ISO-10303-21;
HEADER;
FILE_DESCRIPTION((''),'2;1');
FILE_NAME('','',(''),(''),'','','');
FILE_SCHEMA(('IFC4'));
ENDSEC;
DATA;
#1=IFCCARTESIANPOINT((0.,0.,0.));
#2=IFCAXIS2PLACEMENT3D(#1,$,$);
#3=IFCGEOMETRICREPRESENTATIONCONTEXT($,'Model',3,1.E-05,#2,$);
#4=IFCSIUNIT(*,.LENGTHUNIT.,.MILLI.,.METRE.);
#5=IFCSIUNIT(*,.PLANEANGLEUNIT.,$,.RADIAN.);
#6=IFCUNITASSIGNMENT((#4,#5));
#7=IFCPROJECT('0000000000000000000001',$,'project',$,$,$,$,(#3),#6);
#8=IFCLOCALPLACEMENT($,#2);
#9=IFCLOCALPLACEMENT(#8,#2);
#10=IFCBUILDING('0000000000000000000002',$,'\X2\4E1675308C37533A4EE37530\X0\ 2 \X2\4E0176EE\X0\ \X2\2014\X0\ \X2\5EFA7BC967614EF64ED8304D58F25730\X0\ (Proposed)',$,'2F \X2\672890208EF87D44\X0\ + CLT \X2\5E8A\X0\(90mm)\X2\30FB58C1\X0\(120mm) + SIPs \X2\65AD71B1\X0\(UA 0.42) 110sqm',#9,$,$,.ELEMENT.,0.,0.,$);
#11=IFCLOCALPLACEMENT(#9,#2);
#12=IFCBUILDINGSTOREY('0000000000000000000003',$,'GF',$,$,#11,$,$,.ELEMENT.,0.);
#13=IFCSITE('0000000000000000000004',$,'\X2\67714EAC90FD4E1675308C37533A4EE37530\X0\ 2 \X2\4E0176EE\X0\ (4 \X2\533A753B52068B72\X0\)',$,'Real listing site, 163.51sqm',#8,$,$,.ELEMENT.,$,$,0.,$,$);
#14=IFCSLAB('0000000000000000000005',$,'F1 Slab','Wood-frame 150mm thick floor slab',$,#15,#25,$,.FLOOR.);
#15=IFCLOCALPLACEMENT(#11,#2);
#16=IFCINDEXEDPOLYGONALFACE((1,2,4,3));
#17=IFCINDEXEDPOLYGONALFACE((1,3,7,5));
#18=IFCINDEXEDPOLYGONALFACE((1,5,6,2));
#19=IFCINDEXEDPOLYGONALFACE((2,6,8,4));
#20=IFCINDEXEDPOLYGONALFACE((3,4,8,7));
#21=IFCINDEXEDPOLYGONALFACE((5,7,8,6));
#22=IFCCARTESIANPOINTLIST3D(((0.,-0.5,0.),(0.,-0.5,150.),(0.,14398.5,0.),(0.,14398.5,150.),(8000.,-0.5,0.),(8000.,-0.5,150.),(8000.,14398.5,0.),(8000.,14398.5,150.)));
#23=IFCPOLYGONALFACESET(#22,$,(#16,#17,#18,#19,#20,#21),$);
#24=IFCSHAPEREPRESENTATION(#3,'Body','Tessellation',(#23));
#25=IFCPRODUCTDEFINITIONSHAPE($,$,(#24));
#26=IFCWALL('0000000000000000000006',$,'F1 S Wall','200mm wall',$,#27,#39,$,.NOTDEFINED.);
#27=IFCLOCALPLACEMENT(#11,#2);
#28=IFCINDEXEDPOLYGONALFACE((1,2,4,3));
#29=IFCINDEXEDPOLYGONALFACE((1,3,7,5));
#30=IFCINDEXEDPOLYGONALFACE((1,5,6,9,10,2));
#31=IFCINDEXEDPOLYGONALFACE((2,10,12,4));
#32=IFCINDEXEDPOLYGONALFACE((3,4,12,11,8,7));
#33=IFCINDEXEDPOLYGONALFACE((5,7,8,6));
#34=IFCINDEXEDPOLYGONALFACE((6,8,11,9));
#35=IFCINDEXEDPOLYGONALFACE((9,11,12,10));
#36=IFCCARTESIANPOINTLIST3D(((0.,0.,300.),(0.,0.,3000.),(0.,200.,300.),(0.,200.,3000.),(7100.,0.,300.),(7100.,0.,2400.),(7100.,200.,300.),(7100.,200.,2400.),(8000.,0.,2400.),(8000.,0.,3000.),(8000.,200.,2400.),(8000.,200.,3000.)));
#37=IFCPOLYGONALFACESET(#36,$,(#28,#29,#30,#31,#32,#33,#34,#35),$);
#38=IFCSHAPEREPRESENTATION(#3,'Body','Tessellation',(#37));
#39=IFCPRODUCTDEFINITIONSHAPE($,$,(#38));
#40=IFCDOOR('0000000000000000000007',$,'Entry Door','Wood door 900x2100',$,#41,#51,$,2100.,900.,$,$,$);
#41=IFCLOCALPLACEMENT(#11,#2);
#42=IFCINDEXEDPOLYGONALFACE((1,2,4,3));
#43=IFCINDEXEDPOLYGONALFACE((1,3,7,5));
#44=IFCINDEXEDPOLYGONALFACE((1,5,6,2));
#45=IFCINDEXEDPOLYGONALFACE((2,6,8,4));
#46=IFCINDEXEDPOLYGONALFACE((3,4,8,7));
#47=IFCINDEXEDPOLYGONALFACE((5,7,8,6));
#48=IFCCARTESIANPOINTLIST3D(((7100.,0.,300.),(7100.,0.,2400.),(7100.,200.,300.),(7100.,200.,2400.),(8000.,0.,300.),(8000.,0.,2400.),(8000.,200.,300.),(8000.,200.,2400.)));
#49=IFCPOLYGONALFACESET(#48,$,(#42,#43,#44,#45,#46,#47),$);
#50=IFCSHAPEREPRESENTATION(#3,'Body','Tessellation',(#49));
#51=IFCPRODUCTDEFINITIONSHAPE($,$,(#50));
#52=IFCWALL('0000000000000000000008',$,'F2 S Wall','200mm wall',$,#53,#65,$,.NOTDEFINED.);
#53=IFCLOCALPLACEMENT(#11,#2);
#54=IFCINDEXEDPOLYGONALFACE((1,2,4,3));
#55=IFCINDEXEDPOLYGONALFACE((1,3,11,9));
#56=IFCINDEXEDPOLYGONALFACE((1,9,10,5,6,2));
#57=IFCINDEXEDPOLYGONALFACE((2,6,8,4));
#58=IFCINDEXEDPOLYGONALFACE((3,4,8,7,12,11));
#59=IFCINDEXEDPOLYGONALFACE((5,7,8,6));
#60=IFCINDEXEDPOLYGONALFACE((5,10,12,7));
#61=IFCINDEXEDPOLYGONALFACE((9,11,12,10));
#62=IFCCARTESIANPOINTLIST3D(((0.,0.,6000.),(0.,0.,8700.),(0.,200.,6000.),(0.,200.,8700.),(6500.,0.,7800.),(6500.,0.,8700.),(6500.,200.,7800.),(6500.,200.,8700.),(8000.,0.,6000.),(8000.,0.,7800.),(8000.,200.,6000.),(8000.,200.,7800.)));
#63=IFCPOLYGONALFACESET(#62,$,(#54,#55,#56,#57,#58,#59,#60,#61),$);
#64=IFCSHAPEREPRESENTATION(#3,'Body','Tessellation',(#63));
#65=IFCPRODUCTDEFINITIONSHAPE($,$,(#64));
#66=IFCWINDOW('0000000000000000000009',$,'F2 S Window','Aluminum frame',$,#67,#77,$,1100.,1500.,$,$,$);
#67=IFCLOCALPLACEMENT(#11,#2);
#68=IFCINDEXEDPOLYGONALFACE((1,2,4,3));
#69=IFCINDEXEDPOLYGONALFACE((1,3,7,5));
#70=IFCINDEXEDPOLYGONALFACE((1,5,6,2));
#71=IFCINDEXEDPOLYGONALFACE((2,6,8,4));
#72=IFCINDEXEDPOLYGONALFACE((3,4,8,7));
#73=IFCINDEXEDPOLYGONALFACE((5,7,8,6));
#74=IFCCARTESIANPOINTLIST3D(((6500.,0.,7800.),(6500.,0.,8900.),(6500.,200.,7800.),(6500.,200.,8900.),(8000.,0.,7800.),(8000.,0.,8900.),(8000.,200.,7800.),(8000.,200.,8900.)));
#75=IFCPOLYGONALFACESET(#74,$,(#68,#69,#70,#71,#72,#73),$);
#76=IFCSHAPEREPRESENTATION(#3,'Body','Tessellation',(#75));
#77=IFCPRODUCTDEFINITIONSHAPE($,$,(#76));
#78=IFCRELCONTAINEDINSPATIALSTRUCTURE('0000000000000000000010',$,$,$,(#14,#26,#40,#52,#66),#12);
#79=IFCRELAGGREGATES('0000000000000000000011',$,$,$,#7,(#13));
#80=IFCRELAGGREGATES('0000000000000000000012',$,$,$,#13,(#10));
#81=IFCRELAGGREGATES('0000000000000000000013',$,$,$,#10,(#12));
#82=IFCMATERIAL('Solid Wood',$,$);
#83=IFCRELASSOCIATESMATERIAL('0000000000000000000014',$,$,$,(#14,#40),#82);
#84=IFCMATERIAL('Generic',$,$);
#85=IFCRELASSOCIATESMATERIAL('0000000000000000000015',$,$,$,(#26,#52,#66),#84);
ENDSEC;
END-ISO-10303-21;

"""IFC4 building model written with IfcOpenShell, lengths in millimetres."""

from ifc_helpers import new_model, si_unit, frame, frame_2d, origin, place, context, project, spatial, rectangle, extrude, material, element, fill, save


model = new_model("IFC4")

# Units and contexts
model_context = context("Model", 3, precision=1e-05, world=origin())
ifc_project = project(units=[si_unit("LENGTHUNIT", "METRE", prefix="MILLI"), si_unit("PLANEANGLEUNIT", "RADIAN")], contexts=[model_context])

# Site, building, storey
site_placement = place(None, origin())
site = spatial("IfcSite", under=ifc_project, at=site_placement, Name="東京都世田谷区代田 2 丁目 (4 区画分譲)", ObjectType="Real listing site, 163.51sqm", CompositionType="ELEMENT", RefElevation=0.0)
building_placement = place(site_placement, origin())
building = spatial("IfcBuilding", under=site, at=building_placement, Name="世田谷区代田 2 丁目 — 建築条件付き売地 (Proposed)", ObjectType="2F 木造軸組 + CLT 床(90mm)・壁(120mm) + SIPs 断熱(UA 0.42) 110sqm", CompositionType="ELEMENT", ElevationOfRefHeight=0.0, ElevationOfTerrain=0.0)
storey_placement = place(building_placement, origin())
storey = spatial("IfcBuildingStorey", under=building, at=storey_placement, Name="GF", CompositionType="ELEMENT", Elevation=0.0)

# Slab
ifc_material_1 = material(Name="Solid Wood")
slab_1_placement = place(storey_placement, origin())
element("IfcSlab", 1, at=slab_1_placement, inside=storey, material=ifc_material_1, Name="F1 Slab", Description="Wood-frame 150mm thick floor slab", PredefinedType="FLOOR", context=model_context, shape_type="SweptSolid", body=[
    extrude(rectangle(XDim=8000.0, YDim=14399.0, at=frame_2d((4000.0, 7199.0))), origin(), (0.0, 0.0, 1.0), 150.0),
])

# Shared definitions
ifc_material_2 = material(Name="Generic")

# Wall, opening, door
wall_1_placement = place(storey_placement, frame((0.0, 0.0, 150.0)))
wall_1 = element("IfcWall", 2, at=wall_1_placement, inside=storey, material=ifc_material_2, Name="F1 S Wall", Description="200mm wall", PredefinedType="NOTDEFINED", context=model_context, shape_type="SweptSolid", body=[
    extrude(rectangle(XDim=8000.0, YDim=200.0, at=frame_2d((4000.0, 100.0))), frame((0.0, 0.0, 150.0)), (0.0, 0.0, 1.0), 2700.0),
])
opening_1_placement = place(storey_placement, frame((3550.0, 0.0, 150.0)))
opening_1 = element("IfcOpeningElement", 3, at=opening_1_placement, cuts=wall_1, PredefinedType="NOTDEFINED", context=model_context, shape_type="SweptSolid", body=[
    extrude(rectangle(XDim=900.0, YDim=200.0, at=frame_2d((450.0, 100.0))), frame((3550.0, 0.0, 150.0)), (0.0, 0.0, 1.0), 2100.0),
])
door_placement = place(storey_placement, frame((3550.0, 0.0, 150.0)))
door = element("IfcDoor", 4, at=door_placement, inside=storey, material=ifc_material_1, Name="Entry Door", Description="Wood door 900x2100", OverallHeight=2100.0, OverallWidth=900.0, context=model_context, shape_type="SweptSolid", body=[
    extrude(rectangle(XDim=900.0, YDim=200.0, at=frame_2d((450.0, 100.0))), frame((3550.0, 0.0, 150.0)), (0.0, 0.0, 1.0), 2100.0),
])
fill(opening_1, door)

# Wall, opening, window
wall_2_placement = place(storey_placement, frame((0.0, 0.0, 3000.0)))
wall_2 = element("IfcWall", 5, at=wall_2_placement, inside=storey, material=ifc_material_2, Name="F2 S Wall", Description="200mm wall", PredefinedType="NOTDEFINED", context=model_context, shape_type="SweptSolid", body=[
    extrude(rectangle(XDim=8000.0, YDim=200.0, at=frame_2d((4000.0, 100.0))), frame((0.0, 0.0, 3000.0)), (0.0, 0.0, 1.0), 2700.0),
])
opening_2_placement = place(storey_placement, frame((3250.0, 0.0, 3900.0)))
opening_2 = element("IfcOpeningElement", 6, at=opening_2_placement, cuts=wall_2, PredefinedType="NOTDEFINED", context=model_context, shape_type="SweptSolid", body=[
    extrude(rectangle(XDim=1500.0, YDim=200.0, at=frame_2d((750.0, 100.0))), frame((3250.0, 0.0, 3900.0)), (0.0, 0.0, 1.0), 1100.0),
])
window_1_placement = place(storey_placement, frame((3250.0, 0.0, 3900.0)))
window_1 = element("IfcWindow", 7, at=window_1_placement, inside=storey, material=ifc_material_2, Name="F2 S Window", Description="Aluminum frame", OverallHeight=1100.0, OverallWidth=1500.0, context=model_context, shape_type="SweptSolid", body=[
    extrude(rectangle(XDim=1500.0, YDim=200.0, at=frame_2d((750.0, 100.0))), frame((3250.0, 0.0, 3900.0)), (0.0, 0.0, 1.0), 1100.0),
])
fill(opening_2, window_1)

save(model, "model.ifc")
